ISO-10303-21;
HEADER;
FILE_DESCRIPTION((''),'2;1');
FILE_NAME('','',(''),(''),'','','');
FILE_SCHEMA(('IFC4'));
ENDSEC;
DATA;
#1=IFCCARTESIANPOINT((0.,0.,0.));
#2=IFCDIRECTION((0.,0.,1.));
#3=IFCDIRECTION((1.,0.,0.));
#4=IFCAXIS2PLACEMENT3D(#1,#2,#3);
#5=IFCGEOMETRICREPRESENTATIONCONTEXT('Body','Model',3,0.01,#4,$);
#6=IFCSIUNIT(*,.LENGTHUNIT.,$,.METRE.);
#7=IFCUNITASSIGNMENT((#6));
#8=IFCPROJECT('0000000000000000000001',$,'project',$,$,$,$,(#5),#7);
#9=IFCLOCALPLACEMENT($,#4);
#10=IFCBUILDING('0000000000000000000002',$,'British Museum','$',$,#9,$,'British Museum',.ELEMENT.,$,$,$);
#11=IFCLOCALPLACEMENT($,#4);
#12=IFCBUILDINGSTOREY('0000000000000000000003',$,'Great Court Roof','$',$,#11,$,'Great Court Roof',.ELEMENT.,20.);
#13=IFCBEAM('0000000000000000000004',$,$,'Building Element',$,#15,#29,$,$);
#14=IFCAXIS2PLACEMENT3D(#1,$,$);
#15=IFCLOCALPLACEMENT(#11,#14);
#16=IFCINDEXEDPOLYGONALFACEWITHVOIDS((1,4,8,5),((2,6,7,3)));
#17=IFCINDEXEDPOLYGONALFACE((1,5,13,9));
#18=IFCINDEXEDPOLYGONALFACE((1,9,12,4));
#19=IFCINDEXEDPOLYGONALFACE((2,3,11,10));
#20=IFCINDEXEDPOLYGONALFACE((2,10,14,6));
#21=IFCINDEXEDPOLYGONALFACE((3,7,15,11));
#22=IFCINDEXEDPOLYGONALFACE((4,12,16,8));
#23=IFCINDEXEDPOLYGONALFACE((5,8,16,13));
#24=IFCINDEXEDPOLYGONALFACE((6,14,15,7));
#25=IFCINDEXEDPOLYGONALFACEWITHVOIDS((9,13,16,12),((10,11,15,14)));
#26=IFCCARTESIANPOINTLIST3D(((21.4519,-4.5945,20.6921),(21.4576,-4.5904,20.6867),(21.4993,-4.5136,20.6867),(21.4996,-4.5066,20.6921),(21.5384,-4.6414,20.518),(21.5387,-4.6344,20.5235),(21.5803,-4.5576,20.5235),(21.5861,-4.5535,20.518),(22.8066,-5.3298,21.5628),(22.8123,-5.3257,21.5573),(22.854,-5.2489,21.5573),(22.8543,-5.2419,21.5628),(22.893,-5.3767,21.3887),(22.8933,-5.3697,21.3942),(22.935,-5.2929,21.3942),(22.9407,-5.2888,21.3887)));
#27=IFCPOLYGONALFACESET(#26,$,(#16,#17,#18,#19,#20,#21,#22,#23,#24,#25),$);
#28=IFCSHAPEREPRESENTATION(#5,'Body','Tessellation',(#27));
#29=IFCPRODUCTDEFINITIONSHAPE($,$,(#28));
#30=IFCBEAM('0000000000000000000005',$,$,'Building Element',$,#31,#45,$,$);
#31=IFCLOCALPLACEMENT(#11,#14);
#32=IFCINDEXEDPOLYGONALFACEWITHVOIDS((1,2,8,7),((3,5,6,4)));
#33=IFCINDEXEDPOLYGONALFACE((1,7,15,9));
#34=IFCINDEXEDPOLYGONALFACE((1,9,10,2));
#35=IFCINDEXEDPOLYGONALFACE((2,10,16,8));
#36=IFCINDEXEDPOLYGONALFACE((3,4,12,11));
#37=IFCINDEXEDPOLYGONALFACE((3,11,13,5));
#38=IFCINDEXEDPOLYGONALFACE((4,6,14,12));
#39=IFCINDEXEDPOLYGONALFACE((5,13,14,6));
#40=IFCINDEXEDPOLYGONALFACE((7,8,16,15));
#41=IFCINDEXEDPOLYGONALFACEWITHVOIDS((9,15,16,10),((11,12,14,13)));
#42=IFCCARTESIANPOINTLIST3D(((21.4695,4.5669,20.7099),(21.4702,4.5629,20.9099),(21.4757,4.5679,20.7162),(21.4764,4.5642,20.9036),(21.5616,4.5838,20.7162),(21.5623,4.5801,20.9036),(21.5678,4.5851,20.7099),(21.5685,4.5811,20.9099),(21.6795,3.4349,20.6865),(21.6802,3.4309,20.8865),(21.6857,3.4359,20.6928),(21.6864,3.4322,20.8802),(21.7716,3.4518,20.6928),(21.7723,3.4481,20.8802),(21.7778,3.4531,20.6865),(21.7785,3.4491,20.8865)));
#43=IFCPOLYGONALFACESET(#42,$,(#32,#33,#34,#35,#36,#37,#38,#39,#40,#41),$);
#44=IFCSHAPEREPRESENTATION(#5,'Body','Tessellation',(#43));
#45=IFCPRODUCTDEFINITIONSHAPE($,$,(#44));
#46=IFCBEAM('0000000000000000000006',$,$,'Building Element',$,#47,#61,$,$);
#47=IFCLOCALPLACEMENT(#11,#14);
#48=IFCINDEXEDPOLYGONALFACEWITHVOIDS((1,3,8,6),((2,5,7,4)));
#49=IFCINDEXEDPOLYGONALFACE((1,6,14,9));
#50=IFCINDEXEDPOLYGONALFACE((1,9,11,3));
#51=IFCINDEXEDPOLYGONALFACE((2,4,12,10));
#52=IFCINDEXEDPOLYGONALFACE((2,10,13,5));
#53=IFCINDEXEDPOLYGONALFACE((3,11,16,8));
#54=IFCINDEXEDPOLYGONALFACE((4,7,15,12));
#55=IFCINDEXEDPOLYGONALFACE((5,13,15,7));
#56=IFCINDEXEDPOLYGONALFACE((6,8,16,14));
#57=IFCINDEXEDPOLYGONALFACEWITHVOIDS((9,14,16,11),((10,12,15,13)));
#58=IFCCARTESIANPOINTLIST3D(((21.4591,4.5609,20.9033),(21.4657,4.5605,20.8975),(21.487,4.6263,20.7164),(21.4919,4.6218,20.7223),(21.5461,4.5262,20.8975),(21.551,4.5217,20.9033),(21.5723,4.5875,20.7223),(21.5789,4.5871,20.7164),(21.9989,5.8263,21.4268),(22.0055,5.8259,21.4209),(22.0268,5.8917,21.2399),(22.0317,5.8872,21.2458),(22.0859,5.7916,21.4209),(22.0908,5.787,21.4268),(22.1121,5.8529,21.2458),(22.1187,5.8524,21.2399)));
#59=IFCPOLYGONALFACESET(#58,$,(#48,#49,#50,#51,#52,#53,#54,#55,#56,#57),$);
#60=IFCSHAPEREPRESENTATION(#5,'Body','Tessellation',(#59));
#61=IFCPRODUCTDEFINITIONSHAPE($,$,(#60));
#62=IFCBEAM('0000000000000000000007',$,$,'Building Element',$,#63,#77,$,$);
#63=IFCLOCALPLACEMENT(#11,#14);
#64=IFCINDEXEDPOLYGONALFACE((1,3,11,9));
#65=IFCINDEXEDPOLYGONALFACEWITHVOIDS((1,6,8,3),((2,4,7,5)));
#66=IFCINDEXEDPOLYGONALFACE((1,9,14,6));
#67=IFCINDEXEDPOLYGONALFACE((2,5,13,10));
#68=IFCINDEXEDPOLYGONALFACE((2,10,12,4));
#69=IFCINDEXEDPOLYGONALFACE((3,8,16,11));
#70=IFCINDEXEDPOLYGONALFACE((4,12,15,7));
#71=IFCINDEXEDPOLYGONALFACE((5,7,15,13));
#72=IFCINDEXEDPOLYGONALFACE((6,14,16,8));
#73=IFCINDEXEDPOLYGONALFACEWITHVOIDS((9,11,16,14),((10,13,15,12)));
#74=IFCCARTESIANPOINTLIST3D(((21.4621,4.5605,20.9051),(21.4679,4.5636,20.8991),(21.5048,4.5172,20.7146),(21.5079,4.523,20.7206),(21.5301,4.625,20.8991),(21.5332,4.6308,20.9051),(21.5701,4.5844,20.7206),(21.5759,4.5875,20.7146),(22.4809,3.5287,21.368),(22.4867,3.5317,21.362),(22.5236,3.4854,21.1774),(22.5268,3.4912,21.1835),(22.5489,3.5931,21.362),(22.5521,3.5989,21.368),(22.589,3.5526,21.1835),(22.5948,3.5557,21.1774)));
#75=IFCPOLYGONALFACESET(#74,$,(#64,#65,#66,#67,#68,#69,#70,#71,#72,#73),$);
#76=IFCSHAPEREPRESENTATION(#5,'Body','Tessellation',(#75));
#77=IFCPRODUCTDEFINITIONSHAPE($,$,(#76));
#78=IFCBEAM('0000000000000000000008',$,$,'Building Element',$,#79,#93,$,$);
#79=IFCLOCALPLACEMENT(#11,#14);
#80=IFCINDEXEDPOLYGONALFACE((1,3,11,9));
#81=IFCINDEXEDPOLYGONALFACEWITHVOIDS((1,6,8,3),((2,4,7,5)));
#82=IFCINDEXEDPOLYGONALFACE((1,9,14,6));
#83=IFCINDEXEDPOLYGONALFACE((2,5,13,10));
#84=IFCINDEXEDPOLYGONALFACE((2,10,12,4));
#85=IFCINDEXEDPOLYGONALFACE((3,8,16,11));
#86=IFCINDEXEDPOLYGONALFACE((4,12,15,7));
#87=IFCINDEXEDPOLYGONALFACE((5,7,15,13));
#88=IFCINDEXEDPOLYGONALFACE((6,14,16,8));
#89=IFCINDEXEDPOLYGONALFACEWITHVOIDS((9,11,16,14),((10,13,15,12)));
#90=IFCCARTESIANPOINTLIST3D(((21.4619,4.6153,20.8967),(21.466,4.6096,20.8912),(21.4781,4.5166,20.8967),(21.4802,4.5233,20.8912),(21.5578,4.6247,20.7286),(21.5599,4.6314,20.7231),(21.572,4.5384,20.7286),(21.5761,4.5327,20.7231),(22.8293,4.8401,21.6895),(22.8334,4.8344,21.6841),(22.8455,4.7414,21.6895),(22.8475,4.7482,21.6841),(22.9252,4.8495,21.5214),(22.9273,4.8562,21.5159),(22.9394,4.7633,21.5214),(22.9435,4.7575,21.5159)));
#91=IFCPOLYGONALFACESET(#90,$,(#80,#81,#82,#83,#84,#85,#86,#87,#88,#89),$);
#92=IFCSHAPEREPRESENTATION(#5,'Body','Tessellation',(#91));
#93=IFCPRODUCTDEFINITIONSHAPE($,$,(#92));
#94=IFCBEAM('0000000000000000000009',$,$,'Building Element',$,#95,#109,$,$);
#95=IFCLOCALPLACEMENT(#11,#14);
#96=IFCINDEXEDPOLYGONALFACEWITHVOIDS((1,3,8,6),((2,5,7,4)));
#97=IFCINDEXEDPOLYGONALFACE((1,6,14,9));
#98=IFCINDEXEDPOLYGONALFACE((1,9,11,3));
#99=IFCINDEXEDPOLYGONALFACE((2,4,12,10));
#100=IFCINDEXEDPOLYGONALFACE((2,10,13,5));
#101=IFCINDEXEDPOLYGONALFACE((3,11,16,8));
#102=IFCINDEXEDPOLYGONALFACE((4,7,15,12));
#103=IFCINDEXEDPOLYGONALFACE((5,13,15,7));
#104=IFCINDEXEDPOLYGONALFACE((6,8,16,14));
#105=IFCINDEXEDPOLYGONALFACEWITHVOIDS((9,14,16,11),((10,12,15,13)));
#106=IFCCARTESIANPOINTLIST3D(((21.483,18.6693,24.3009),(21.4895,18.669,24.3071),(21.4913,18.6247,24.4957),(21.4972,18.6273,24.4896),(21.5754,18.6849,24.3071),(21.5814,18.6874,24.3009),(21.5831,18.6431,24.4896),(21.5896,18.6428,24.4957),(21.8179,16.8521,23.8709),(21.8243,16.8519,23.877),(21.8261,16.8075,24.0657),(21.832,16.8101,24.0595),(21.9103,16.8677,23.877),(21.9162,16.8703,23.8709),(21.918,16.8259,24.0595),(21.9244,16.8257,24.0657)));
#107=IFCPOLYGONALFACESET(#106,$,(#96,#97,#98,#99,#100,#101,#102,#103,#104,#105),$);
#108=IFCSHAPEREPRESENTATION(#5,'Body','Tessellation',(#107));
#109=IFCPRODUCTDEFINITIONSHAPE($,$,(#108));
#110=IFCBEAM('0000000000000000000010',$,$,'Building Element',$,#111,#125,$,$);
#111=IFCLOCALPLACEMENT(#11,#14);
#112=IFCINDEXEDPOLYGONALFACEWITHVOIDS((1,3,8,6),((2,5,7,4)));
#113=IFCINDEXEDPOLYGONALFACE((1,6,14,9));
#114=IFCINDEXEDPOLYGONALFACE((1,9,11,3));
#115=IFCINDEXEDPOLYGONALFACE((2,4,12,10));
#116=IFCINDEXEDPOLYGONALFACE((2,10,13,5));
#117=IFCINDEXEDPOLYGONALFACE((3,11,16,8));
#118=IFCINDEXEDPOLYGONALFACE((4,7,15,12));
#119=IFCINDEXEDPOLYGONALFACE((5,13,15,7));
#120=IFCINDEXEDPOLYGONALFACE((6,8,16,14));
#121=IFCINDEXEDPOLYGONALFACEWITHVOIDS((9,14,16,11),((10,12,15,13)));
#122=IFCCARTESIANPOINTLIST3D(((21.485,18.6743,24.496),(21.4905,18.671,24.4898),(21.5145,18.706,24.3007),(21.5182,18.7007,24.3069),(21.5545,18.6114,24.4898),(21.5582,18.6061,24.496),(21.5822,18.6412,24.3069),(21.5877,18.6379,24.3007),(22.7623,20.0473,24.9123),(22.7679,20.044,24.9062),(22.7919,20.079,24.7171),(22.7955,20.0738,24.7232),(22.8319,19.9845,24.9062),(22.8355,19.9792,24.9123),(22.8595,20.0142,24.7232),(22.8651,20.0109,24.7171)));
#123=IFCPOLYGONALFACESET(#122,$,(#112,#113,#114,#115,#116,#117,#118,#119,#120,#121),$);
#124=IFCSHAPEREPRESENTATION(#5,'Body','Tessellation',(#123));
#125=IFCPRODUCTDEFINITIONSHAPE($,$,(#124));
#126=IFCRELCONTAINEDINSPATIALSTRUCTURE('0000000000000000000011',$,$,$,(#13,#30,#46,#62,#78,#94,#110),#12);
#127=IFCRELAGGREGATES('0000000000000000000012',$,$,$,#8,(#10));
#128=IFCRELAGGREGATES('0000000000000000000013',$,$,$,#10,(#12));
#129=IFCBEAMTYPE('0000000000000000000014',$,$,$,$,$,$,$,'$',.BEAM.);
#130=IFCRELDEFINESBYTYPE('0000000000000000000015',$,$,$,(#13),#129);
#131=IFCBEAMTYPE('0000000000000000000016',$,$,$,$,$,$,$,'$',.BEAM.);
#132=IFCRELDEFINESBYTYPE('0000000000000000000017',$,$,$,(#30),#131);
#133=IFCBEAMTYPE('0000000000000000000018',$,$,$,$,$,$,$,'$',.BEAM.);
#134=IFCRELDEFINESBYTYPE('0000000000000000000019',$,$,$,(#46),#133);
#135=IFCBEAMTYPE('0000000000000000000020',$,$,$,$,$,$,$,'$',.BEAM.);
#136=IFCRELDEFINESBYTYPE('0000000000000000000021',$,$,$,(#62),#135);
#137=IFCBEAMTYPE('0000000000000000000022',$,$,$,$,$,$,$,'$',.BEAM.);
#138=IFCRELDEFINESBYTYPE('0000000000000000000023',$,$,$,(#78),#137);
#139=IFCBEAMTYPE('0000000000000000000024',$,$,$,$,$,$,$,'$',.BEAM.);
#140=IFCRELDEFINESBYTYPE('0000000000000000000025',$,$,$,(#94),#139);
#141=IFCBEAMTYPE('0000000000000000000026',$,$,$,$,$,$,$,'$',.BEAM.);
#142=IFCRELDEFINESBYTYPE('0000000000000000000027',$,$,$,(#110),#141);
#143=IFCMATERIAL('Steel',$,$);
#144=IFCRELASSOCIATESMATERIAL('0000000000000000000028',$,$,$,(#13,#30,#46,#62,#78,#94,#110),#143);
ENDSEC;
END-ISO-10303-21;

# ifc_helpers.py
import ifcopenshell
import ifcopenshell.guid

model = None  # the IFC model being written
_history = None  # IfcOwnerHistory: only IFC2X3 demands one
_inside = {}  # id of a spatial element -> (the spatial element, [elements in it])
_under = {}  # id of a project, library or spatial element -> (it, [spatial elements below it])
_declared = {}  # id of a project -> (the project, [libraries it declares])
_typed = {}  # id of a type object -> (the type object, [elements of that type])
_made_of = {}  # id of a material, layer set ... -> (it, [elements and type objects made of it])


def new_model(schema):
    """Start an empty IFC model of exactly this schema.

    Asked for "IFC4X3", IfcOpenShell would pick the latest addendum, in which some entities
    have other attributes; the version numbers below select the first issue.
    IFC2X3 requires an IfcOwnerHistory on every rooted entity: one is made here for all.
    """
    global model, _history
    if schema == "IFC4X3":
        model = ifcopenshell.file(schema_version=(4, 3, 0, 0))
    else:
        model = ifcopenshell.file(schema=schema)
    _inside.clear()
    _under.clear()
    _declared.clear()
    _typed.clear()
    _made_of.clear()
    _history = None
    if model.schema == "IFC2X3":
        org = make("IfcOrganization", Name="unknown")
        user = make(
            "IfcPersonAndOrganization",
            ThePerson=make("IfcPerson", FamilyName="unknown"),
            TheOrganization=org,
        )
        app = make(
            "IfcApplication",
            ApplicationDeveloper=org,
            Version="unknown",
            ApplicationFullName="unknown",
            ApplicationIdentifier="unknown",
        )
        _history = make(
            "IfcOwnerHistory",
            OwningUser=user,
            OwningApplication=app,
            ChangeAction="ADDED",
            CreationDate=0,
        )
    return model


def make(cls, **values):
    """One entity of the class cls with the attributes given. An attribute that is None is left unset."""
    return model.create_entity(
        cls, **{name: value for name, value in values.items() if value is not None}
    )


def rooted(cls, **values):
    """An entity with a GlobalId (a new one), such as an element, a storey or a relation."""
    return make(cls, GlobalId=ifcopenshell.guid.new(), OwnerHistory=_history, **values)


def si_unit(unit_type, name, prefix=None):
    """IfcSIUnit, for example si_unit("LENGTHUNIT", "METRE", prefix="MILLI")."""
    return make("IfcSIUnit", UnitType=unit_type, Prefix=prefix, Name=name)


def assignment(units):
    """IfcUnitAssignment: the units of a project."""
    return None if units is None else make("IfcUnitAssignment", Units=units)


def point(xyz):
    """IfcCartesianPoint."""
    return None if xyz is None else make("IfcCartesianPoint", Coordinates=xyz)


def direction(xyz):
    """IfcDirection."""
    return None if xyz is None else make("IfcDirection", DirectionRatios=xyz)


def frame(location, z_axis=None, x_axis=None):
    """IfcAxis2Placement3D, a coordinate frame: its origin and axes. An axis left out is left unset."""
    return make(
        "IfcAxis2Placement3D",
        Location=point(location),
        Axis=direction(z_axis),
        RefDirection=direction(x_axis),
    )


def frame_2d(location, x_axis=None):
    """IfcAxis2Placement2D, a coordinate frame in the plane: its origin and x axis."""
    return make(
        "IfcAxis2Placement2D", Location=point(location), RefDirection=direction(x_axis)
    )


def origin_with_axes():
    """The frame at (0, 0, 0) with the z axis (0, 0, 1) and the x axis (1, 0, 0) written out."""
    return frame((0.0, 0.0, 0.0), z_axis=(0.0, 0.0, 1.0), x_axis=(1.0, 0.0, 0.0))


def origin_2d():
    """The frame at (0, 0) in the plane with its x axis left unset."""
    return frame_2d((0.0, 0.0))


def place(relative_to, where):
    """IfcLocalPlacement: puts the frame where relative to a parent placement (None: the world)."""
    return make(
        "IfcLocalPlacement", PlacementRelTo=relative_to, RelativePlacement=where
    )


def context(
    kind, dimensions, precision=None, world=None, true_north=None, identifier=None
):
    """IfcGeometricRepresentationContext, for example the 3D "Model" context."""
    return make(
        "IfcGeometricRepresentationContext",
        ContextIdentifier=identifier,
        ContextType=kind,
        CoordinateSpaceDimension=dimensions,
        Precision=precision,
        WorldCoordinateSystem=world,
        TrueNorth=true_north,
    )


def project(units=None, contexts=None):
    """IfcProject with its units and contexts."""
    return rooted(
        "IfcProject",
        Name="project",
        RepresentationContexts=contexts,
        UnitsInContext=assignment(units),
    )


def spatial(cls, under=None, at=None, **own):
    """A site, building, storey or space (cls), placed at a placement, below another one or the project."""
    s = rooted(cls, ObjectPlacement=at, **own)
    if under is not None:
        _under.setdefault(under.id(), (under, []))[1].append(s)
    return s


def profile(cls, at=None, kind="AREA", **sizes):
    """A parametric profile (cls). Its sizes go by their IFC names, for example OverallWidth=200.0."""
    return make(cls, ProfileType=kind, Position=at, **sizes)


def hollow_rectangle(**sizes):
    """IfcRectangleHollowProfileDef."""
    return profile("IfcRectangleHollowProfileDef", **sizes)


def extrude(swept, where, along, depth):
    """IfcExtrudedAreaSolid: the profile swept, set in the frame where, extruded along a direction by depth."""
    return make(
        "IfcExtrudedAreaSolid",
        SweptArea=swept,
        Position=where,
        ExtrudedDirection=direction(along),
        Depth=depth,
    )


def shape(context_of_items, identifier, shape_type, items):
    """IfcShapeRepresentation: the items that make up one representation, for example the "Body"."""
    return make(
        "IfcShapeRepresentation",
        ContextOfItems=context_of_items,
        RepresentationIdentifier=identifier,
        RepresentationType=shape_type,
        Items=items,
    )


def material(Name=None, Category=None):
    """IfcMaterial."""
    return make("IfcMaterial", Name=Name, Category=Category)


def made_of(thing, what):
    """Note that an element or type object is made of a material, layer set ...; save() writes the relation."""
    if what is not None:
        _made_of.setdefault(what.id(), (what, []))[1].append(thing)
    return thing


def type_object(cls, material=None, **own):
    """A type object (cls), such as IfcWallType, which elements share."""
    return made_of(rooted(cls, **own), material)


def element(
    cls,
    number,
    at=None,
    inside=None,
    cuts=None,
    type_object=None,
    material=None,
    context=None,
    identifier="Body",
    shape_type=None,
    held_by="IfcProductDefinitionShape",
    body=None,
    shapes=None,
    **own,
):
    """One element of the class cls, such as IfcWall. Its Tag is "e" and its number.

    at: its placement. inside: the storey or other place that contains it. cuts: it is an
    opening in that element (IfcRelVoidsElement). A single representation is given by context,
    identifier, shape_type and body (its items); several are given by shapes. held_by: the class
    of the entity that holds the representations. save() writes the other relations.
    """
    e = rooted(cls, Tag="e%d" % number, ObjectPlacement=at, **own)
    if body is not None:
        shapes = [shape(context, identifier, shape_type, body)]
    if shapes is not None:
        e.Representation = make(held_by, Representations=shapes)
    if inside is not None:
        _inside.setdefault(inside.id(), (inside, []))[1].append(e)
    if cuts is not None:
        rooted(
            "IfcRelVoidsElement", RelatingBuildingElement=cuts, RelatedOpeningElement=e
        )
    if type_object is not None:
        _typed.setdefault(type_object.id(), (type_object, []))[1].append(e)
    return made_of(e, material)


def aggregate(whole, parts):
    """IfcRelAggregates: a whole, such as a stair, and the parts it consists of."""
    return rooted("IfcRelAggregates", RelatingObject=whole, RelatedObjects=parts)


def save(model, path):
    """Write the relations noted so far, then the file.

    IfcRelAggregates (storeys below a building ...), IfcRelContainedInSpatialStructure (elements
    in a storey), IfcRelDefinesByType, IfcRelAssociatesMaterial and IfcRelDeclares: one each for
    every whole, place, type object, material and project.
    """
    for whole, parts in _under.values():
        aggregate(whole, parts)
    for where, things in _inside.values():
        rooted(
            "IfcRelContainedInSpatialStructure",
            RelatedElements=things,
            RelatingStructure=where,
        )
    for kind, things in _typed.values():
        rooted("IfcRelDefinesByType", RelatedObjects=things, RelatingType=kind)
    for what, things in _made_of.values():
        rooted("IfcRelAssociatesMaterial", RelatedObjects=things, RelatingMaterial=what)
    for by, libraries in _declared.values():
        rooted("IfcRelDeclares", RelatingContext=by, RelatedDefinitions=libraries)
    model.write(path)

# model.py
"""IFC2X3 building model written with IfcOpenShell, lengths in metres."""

from ifc_helpers import new_model, si_unit, frame, origin_with_axes, origin_2d, place, context, project, spatial, hollow_rectangle, extrude, material, type_object, element, save


model = new_model("IFC2X3")

# Units and contexts
model_context = context("Model", 3, precision=0.01, world=origin_with_axes(), identifier="Body")
ifc_project = project(units=[si_unit("LENGTHUNIT", "METRE")], contexts=[model_context])

# Building, storey
building_placement = place(None, origin_with_axes())
building = spatial("IfcBuilding", under=ifc_project, at=building_placement, Name="British Museum", Description="$", LongName="British Museum", CompositionType="ELEMENT")
storey_placement = place(None, origin_with_axes())
storey = spatial("IfcBuildingStorey", under=building, at=storey_placement, Name="Great Court Roof", Description="$", LongName="Great Court Roof", CompositionType="ELEMENT", Elevation=20.0)

# Beams
ifc_material = material(Name="Steel")
beam_type_1 = type_object("IfcBeamType", ElementType="$", PredefinedType="BEAM")
beam_1_placement = place(None, origin_with_axes())
element("IfcBeam", 1, at=beam_1_placement, inside=storey, type_object=beam_type_1, material=ifc_material, Description="Building Element", context=model_context, shape_type="SweptSolid", body=[
    extrude(hollow_rectangle(XDim=0.1, YDim=0.2, WallThickness=0.0063, InnerFilletRadius=0.0, OuterFilletRadius=0.0, at=origin_2d()), frame((21.519, -4.574, 20.6051), z_axis=(0.765236, -0.415355, 0.491827), x_axis=(0.477039, 0.878882, 0.0)), (0.0, 0.0, 1.0), 1.7703),
])
beam_type_2 = type_object("IfcBeamType", ElementType="$", PredefinedType="BEAM")
beam_2_placement = place(None, origin_with_axes())
element("IfcBeam", 2, at=beam_2_placement, inside=storey, type_object=beam_type_2, material=ifc_material, Description="Building Element", context=model_context, shape_type="SweptSolid", body=[
    extrude(hollow_rectangle(XDim=0.1, YDim=0.2, WallThickness=0.0063, InnerFilletRadius=0.0, OuterFilletRadius=0.0, at=origin_2d()), frame((21.519, 4.574, 20.8099), z_axis=(0.182364, -0.983021, -0.020307), x_axis=(0.983224, 0.182401, 0.0)), (0.0, 0.0, 1.0), 1.1516),
])
beam_type_3 = type_object("IfcBeamType", ElementType="$", PredefinedType="BEAM")
beam_3_placement = place(None, origin_with_axes())
element("IfcBeam", 3, at=beam_3_placement, inside=storey, type_object=beam_type_3, material=ifc_material, Description="Building Element", context=model_context, shape_type="SweptSolid", body=[
    extrude(hollow_rectangle(XDim=0.1, YDim=0.2, WallThickness=0.0063, InnerFilletRadius=0.0, OuterFilletRadius=0.0, at=origin_2d()), frame((21.519, 4.574, 20.8099), z_axis=(0.366731, 0.859666, 0.355644), x_axis=(-0.919801, 0.392384, 0.0)), (0.0, 0.0, 1.0), 1.4719),
])
beam_type_4 = type_object("IfcBeamType", ElementType="$", PredefinedType="BEAM")
beam_4_placement = place(None, origin_with_axes())
element("IfcBeam", 4, at=beam_4_placement, inside=storey, type_object=beam_type_4, material=ifc_material, Description="Building Element", context=model_context, shape_type="SweptSolid", body=[
    extrude(hollow_rectangle(XDim=0.1, YDim=0.2, WallThickness=0.0063, InnerFilletRadius=0.0, OuterFilletRadius=0.0, at=origin_2d()), frame((21.519, 4.574, 20.8099), z_axis=(0.669351, -0.677875, 0.304064), x_axis=(0.711566, 0.702619, 0.0)), (0.0, 0.0, 1.0), 1.5222),
])
beam_type_5 = type_object("IfcBeamType", ElementType="$", PredefinedType="BEAM")
beam_5_placement = place(None, origin_with_axes())
element("IfcBeam", 5, at=beam_5_placement, inside=storey, type_object=beam_type_5, material=ifc_material, Description="Building Element", context=model_context, shape_type="SweptSolid", body=[
    extrude(hollow_rectangle(XDim=0.1, YDim=0.2, WallThickness=0.0063, InnerFilletRadius=0.0, OuterFilletRadius=0.0, at=origin_2d()), frame((21.519, 4.574, 20.8099), z_axis=(0.856471, 0.140825, 0.496614), x_axis=(-0.162246, 0.98675, 0.0)), (0.0, 0.0, 1.0), 1.5965),
])
beam_type_6 = type_object("IfcBeamType", ElementType="$", PredefinedType="BEAM")
beam_6_placement = place(None, origin_with_axes())
element("IfcBeam", 6, at=beam_6_placement, inside=storey, type_object=beam_type_6, material=ifc_material, Description="Building Element", context=model_context, shape_type="SweptSolid", body=[
    extrude(hollow_rectangle(XDim=0.1, YDim=0.2, WallThickness=0.0063, InnerFilletRadius=0.0, OuterFilletRadius=0.0, at=origin_2d()), frame((21.5363, 18.6561, 24.3983), z_axis=(0.176482, -0.957846, -0.226684), x_axis=(0.983447, 0.181198, 0.0)), (0.0, 0.0, 1.0), 1.8971),
])
beam_type_7 = type_object("IfcBeamType", ElementType="$", PredefinedType="BEAM")
beam_7_placement = place(None, origin_with_axes())
element("IfcBeam", 7, at=beam_7_placement, inside=storey, type_object=beam_type_7, material=ifc_material, Description="Building Element", context=model_context, shape_type="SweptSolid", body=[
    extrude(hollow_rectangle(XDim=0.1, YDim=0.2, WallThickness=0.0063, InnerFilletRadius=0.0, OuterFilletRadius=0.0, at=origin_2d()), frame((21.5363, 18.6561, 24.3983), z_axis=(0.664951, 0.714746, 0.216745), x_axis=(-0.732151, 0.681143, 0.0)), (0.0, 0.0, 1.0), 1.921),
])

save(model, "model.ifc")
